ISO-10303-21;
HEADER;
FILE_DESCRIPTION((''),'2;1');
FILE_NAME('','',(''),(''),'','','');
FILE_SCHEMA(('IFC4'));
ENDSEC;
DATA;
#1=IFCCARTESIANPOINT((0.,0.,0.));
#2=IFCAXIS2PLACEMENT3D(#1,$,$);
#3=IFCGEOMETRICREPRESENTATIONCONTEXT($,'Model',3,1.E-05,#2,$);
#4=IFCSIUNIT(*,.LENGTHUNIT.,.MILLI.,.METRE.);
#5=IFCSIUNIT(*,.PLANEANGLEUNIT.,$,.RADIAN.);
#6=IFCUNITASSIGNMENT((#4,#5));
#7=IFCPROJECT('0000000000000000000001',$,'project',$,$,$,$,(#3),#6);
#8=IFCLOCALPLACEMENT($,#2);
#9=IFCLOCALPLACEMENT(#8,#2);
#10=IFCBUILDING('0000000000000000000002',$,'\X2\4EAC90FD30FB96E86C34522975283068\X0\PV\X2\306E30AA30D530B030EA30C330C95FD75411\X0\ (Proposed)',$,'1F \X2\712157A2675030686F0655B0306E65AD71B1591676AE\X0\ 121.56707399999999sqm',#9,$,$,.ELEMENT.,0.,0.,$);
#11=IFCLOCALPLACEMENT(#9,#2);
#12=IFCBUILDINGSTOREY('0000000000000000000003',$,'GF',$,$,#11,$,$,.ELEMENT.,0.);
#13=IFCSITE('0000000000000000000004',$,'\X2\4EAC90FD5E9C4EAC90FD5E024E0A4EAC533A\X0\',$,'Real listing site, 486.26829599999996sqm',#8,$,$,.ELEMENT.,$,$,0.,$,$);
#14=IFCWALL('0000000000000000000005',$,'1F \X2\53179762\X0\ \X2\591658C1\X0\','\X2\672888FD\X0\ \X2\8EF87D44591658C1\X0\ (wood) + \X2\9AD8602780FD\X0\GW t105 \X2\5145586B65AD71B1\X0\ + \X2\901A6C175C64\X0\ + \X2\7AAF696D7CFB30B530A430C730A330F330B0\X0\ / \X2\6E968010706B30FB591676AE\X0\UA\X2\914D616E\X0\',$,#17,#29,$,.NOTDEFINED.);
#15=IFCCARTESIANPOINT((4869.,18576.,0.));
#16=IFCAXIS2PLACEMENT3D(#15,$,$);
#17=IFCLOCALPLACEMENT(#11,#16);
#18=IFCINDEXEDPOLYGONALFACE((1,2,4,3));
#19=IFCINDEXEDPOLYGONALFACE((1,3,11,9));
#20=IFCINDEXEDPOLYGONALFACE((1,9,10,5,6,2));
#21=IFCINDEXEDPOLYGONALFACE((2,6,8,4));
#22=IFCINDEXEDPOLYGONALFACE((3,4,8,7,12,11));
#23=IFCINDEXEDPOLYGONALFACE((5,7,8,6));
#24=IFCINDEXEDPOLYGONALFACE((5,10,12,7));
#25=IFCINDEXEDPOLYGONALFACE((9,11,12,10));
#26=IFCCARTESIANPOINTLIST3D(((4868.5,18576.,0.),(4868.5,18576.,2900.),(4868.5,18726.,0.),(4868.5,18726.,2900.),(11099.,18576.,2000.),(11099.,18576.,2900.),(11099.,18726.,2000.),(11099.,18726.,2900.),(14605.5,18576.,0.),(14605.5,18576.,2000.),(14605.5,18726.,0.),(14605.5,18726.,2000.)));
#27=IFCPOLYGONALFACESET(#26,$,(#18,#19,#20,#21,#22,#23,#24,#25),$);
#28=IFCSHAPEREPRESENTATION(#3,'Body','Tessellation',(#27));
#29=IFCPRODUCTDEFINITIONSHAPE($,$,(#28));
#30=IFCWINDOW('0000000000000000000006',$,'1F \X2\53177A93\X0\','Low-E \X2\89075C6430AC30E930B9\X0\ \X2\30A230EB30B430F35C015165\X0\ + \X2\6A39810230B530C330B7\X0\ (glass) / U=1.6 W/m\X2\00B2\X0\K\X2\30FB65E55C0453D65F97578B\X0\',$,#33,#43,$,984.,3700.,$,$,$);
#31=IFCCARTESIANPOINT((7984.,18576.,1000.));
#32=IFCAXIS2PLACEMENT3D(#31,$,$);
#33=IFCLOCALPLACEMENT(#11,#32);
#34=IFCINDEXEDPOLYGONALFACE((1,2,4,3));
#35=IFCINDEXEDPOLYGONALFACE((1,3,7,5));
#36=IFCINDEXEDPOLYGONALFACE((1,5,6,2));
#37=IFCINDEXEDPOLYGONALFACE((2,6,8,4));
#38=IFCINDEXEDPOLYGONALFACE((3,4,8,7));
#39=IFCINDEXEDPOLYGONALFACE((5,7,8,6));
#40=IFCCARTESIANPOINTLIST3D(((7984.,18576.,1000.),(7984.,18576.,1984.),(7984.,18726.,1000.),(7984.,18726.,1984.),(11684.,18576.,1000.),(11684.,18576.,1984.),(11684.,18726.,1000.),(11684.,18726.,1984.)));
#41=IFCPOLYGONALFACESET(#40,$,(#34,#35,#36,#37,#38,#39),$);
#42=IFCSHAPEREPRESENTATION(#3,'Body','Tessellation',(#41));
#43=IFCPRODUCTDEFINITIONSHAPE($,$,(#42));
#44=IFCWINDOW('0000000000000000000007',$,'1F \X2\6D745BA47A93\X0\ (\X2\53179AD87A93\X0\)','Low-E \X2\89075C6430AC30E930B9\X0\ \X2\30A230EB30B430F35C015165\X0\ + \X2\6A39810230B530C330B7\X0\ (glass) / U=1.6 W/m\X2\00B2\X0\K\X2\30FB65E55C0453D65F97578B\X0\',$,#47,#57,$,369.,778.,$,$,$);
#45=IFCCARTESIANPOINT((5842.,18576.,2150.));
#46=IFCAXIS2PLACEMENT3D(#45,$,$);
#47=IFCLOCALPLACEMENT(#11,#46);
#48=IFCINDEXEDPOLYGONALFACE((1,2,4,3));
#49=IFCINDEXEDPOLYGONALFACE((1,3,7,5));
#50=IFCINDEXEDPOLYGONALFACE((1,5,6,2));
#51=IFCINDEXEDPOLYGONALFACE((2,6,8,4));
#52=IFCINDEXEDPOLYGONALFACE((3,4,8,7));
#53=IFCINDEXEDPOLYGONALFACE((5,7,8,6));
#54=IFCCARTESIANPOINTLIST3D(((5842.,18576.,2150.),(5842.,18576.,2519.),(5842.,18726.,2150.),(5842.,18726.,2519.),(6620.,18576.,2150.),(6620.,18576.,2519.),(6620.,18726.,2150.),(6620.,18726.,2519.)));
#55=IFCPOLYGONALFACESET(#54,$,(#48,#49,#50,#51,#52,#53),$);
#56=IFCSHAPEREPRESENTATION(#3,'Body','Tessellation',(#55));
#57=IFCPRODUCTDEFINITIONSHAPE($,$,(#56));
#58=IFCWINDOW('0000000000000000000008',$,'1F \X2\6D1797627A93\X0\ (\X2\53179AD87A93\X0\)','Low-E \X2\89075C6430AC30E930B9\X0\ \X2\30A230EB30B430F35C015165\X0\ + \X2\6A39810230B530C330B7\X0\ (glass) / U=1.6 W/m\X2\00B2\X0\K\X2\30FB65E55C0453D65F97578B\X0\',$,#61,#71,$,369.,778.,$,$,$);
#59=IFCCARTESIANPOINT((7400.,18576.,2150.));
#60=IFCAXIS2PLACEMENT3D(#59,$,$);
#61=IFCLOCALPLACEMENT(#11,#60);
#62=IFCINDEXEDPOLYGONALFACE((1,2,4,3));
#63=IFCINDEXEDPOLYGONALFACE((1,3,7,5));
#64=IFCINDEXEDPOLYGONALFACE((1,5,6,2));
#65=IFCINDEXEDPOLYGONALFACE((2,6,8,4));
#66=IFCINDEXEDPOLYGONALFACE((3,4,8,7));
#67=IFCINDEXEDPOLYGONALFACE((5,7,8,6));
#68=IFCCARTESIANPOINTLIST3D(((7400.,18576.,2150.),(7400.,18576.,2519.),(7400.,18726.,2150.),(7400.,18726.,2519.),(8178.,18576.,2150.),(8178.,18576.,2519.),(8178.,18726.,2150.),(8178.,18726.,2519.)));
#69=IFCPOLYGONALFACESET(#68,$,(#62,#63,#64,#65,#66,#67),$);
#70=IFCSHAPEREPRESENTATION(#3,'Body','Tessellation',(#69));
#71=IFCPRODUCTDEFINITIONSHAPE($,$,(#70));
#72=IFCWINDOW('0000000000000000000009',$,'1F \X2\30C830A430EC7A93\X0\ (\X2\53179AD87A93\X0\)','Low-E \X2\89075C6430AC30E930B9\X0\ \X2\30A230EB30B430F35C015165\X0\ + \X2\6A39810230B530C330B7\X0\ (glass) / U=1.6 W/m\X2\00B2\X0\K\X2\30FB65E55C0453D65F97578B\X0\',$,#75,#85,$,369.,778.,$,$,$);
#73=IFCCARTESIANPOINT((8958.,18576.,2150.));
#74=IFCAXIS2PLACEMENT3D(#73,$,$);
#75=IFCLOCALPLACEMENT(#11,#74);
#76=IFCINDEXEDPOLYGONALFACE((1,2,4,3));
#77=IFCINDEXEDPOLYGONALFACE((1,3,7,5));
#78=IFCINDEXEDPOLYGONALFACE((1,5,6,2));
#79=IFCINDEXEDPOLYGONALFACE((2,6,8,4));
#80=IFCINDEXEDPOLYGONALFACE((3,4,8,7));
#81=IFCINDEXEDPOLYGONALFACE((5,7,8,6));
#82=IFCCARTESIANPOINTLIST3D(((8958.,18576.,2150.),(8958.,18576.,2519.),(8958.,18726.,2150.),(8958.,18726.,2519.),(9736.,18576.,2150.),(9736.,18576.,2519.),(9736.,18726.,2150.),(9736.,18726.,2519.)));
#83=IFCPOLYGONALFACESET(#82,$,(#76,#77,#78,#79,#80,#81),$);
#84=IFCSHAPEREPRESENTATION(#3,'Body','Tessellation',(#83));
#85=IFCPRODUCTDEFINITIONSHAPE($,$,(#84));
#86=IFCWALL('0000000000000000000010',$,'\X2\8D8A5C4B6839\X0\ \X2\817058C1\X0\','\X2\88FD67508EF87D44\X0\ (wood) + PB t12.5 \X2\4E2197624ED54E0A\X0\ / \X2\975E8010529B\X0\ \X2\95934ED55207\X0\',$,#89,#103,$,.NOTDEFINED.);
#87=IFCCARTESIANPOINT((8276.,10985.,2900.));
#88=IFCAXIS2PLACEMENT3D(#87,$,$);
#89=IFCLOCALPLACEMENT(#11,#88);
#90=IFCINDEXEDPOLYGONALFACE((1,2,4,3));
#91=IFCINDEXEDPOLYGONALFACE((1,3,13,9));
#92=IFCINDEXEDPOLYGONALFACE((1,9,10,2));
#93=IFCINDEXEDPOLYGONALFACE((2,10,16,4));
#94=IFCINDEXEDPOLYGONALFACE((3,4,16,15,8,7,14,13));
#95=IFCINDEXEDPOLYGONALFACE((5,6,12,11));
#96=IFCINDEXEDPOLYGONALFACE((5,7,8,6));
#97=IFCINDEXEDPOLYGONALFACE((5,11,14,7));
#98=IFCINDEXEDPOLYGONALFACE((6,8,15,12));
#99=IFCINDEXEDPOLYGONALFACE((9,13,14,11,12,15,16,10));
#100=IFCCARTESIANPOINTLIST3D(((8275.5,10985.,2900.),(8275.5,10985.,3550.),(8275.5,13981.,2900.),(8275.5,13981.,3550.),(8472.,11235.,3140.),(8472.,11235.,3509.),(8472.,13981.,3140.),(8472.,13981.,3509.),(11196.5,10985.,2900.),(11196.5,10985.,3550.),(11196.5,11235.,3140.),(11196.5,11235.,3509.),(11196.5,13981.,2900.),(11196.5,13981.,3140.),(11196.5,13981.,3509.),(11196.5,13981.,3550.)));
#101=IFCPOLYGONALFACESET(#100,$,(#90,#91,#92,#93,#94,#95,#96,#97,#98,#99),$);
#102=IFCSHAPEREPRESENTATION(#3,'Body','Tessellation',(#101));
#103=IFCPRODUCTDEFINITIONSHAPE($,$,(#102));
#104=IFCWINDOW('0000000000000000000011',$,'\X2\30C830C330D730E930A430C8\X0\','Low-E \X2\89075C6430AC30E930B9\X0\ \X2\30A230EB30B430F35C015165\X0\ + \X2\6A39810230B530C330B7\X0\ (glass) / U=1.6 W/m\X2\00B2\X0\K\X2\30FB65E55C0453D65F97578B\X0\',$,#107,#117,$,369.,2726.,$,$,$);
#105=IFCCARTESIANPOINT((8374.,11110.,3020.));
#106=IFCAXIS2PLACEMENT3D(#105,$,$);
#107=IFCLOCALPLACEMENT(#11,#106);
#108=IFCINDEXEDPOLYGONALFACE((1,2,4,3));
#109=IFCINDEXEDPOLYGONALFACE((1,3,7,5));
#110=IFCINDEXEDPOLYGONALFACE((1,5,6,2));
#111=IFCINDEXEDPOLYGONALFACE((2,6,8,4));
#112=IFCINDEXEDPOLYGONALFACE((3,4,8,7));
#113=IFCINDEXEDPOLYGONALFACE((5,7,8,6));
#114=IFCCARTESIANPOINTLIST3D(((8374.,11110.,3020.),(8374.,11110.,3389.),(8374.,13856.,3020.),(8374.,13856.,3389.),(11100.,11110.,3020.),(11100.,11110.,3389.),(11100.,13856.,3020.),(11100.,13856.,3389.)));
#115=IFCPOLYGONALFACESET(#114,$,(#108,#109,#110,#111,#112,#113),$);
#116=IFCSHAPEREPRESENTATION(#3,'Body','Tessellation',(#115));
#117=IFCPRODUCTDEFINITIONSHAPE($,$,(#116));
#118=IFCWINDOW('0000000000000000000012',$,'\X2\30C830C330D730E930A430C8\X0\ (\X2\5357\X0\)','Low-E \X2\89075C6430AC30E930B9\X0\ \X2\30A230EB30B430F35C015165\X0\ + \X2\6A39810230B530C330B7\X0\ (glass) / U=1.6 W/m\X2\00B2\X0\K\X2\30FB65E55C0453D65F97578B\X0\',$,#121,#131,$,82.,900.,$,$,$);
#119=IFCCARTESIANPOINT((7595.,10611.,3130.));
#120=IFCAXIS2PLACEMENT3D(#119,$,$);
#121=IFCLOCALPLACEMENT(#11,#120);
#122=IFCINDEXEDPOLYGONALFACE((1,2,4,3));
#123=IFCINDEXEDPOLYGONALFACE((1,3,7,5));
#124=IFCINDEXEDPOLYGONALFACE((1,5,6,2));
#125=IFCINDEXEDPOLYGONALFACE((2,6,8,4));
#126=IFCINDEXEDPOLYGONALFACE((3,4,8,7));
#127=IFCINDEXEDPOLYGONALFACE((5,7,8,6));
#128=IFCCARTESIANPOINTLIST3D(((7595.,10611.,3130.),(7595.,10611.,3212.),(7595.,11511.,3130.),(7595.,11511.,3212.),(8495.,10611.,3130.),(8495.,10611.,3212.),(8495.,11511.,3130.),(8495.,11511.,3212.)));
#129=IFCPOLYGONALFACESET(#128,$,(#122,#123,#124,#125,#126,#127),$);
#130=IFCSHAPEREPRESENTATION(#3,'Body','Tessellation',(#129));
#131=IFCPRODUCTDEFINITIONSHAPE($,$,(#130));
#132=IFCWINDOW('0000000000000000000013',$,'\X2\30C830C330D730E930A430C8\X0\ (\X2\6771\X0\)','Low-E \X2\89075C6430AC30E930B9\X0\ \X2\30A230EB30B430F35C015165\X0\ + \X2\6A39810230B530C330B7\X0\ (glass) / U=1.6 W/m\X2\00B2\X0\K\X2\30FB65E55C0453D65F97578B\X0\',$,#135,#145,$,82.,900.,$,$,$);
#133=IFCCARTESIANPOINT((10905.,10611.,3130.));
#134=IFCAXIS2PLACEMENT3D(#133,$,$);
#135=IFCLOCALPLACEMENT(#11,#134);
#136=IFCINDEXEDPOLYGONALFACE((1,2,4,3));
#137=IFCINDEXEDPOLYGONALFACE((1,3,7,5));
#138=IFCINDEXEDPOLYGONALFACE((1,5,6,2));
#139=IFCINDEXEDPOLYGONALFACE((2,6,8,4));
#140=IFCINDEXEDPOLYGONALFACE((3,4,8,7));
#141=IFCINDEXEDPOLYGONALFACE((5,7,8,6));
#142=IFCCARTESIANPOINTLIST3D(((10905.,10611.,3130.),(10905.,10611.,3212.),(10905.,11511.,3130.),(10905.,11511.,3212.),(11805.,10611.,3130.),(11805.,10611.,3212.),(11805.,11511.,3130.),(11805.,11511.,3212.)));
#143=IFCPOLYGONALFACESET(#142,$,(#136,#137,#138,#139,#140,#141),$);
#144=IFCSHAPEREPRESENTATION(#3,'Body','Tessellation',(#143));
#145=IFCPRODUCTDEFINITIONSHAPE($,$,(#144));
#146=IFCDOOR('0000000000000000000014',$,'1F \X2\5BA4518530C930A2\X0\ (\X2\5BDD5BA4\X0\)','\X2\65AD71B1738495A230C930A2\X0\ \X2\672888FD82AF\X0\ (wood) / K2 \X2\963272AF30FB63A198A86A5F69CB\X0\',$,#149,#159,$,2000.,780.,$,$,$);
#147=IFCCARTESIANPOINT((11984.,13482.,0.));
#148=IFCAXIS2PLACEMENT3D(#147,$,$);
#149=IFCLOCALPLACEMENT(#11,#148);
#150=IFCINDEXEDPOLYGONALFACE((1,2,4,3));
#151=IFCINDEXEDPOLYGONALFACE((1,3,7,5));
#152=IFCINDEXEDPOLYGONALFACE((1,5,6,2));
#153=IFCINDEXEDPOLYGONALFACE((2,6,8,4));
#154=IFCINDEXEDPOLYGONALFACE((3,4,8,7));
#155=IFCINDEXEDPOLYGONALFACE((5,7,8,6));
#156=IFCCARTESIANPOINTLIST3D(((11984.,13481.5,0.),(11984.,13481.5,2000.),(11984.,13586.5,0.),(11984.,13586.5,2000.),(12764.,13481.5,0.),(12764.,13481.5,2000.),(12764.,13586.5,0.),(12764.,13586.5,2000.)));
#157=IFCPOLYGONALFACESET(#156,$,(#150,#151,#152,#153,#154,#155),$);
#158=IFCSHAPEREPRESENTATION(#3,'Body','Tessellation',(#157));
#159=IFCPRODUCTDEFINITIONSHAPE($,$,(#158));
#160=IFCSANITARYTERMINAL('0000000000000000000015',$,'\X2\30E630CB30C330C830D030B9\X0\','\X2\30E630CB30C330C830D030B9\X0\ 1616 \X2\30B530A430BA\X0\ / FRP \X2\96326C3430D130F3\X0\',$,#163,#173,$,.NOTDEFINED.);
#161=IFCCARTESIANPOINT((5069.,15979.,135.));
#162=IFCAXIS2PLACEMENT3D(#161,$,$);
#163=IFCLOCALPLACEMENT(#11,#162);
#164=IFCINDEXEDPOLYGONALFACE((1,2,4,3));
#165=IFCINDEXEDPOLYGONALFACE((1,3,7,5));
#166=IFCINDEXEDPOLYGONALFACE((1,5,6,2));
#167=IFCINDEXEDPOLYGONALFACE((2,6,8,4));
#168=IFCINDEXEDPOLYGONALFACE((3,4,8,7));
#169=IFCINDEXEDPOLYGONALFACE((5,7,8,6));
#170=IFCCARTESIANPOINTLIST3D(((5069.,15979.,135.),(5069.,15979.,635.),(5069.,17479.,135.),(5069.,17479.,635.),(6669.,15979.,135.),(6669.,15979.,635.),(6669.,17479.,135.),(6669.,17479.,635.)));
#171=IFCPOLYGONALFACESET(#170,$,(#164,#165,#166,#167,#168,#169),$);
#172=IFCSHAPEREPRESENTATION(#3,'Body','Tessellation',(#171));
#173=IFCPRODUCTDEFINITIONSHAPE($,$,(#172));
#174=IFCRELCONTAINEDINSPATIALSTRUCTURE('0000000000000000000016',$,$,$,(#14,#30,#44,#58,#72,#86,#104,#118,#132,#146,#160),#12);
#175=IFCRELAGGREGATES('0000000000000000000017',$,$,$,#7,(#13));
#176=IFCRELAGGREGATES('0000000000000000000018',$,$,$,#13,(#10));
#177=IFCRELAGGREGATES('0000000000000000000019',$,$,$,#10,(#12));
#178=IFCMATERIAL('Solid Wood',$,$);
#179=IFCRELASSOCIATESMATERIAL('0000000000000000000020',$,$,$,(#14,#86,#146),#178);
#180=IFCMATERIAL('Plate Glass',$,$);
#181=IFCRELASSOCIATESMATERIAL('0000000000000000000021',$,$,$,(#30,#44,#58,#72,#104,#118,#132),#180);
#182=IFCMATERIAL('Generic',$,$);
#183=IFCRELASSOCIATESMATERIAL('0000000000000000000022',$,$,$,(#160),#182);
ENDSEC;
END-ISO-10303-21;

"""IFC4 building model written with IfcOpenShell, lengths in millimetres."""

from ifc_helpers import new_model, si_unit, frame, frame_2d, origin, place, context, project, spatial, rectangle, extrude, material, element, fill, save


model = new_model("IFC4")

# Units and contexts
model_context = context("Model", 3, precision=1e-05, world=origin())
ifc_project = project(units=[si_unit("LENGTHUNIT", "METRE", prefix="MILLI"), si_unit("PLANEANGLEUNIT", "RADIAN")], contexts=[model_context])

# Site, building, storey
site_placement = place(None, origin())
site = spatial("IfcSite", under=ifc_project, at=site_placement, Name="京都府京都市上京区", ObjectType="Real listing site, 486.26829599999996sqm", CompositionType="ELEMENT", RefElevation=0.0)
building_placement = place(site_placement, origin())
building = spatial("IfcBuilding", under=site, at=building_placement, Name="京都・雨水利用とPVのオフグリッド志向 (Proposed)", ObjectType="1F 無垢材と漆喰の断熱外皮 121.56707399999999sqm", CompositionType="ELEMENT", ElevationOfRefHeight=0.0, ElevationOfTerrain=0.0)
storey_placement = place(building_placement, origin())
storey = spatial("IfcBuildingStorey", under=building, at=storey_placement, Name="GF", CompositionType="ELEMENT", Elevation=0.0)

# Shared definitions
ifc_material_1 = material(Name="Solid Wood")

# Wall, openings, windows
wall_1_placement = place(storey_placement, frame((4869.0, 18576.0, 0.0)))
wall_1 = element("IfcWall", 1, at=wall_1_placement, inside=storey, material=ifc_material_1, Name="1F 北面 外壁", Description="木製 軸組外壁 (wood) + 高性能GW t105 充填断熱 + 通気層 + 窯業系サイディング / 準耐火・外皮UA配慮", PredefinedType="NOTDEFINED", context=model_context, shape_type="SweptSolid", body=[
    extrude(rectangle(XDim=9737.0, YDim=150.0, at=frame_2d((4868.0, 75.0))), frame((4869.0, 18576.0, 0.0)), (0.0, 0.0, 1.0), 2900.0),
])
opening_1_placement = place(storey_placement, frame((7984.0, 18576.0, 1000.0)))
opening_1 = element("IfcOpeningElement", 2, at=opening_1_placement, cuts=wall_1, PredefinedType="NOTDEFINED", context=model_context, shape_type="SweptSolid", body=[
    extrude(rectangle(XDim=3700.0, YDim=150.0, at=frame_2d((1850.0, 75.0))), frame((7984.0, 18576.0, 1000.0)), (0.0, 0.0, 1.0), 984.0),
])
opening_2_placement = place(storey_placement, frame((5842.0, 18576.0, 2150.0)))
opening_2 = element("IfcOpeningElement", 3, at=opening_2_placement, cuts=wall_1, PredefinedType="NOTDEFINED", context=model_context, shape_type="SweptSolid", body=[
    extrude(rectangle(XDim=778.0, YDim=150.0, at=frame_2d((389.0, 75.0))), frame((5842.0, 18576.0, 2150.0)), (0.0, 0.0, 1.0), 369.0),
])
opening_3_placement = place(storey_placement, frame((7400.0, 18576.0, 2150.0)))
opening_3 = element("IfcOpeningElement", 4, at=opening_3_placement, cuts=wall_1, PredefinedType="NOTDEFINED", context=model_context, shape_type="SweptSolid", body=[
    extrude(rectangle(XDim=778.0, YDim=150.0, at=frame_2d((389.0, 75.0))), frame((7400.0, 18576.0, 2150.0)), (0.0, 0.0, 1.0), 369.0),
])
opening_4_placement = place(storey_placement, frame((8958.0, 18576.0, 2150.0)))
opening_4 = element("IfcOpeningElement", 5, at=opening_4_placement, cuts=wall_1, PredefinedType="NOTDEFINED", context=model_context, shape_type="SweptSolid", body=[
    extrude(rectangle(XDim=778.0, YDim=150.0, at=frame_2d((389.0, 75.0))), frame((8958.0, 18576.0, 2150.0)), (0.0, 0.0, 1.0), 369.0),
])
ifc_material_2 = material(Name="Plate Glass")
window_1_placement = place(storey_placement, frame((7984.0, 18576.0, 1000.0)))
window_1 = element("IfcWindow", 6, at=window_1_placement, inside=storey, material=ifc_material_2, Name="1F 北窓", Description="Low-E 複層ガラス アルゴン封入 + 樹脂サッシ (glass) / U=1.6 W/m²K・日射取得型", OverallHeight=984.0, OverallWidth=3700.0, context=model_context, shape_type="SweptSolid", body=[
    extrude(rectangle(XDim=3700.0, YDim=150.0, at=frame_2d((1850.0, 75.0))), frame((7984.0, 18576.0, 1000.0)), (0.0, 0.0, 1.0), 984.0),
])
fill(opening_1, window_1)
window_2_placement = place(storey_placement, frame((5842.0, 18576.0, 2150.0)))
window_2 = element("IfcWindow", 7, at=window_2_placement, inside=storey, material=ifc_material_2, Name="1F 浴室窓 (北高窓)", Description="Low-E 複層ガラス アルゴン封入 + 樹脂サッシ (glass) / U=1.6 W/m²K・日射取得型", OverallHeight=369.0, OverallWidth=778.0, context=model_context, shape_type="SweptSolid", body=[
    extrude(rectangle(XDim=778.0, YDim=150.0, at=frame_2d((389.0, 75.0))), frame((5842.0, 18576.0, 2150.0)), (0.0, 0.0, 1.0), 369.0),
])
fill(opening_2, window_2)
window_3_placement = place(storey_placement, frame((7400.0, 18576.0, 2150.0)))
window_3 = element("IfcWindow", 8, at=window_3_placement, inside=storey, material=ifc_material_2, Name="1F 洗面窓 (北高窓)", Description="Low-E 複層ガラス アルゴン封入 + 樹脂サッシ (glass) / U=1.6 W/m²K・日射取得型", OverallHeight=369.0, OverallWidth=778.0, context=model_context, shape_type="SweptSolid", body=[
    extrude(rectangle(XDim=778.0, YDim=150.0, at=frame_2d((389.0, 75.0))), frame((7400.0, 18576.0, 2150.0)), (0.0, 0.0, 1.0), 369.0),
])
fill(opening_3, window_3)
window_4_placement = place(storey_placement, frame((8958.0, 18576.0, 2150.0)))
window_4 = element("IfcWindow", 9, at=window_4_placement, inside=storey, material=ifc_material_2, Name="1F トイレ窓 (北高窓)", Description="Low-E 複層ガラス アルゴン封入 + 樹脂サッシ (glass) / U=1.6 W/m²K・日射取得型", OverallHeight=369.0, OverallWidth=778.0, context=model_context, shape_type="SweptSolid", body=[
    extrude(rectangle(XDim=778.0, YDim=150.0, at=frame_2d((389.0, 75.0))), frame((8958.0, 18576.0, 2150.0)), (0.0, 0.0, 1.0), 369.0),
])
fill(opening_4, window_4)

# Wall, openings, windows
wall_2_placement = place(storey_placement, frame((8276.0, 10985.0, 2900.0)))
wall_2 = element("IfcWall", 10, at=wall_2_placement, inside=storey, material=ifc_material_1, Name="越屋根 腰壁", Description="製材軸組 (wood) + PB t12.5 両面仕上 / 非耐力 間仕切", PredefinedType="NOTDEFINED", context=model_context, shape_type="SweptSolid", body=[
    extrude(rectangle(XDim=2921.0, YDim=2996.0, at=frame_2d((1460.0, 1498.0))), frame((8276.0, 10985.0, 2900.0)), (0.0, 0.0, 1.0), 650.0),
])
opening_5_placement = place(storey_placement, frame((8374.0, 11110.0, 3020.0)))
opening_5 = element("IfcOpeningElement", 11, at=opening_5_placement, cuts=wall_2, PredefinedType="NOTDEFINED", context=model_context, shape_type="SweptSolid", body=[
    extrude(rectangle(XDim=2726.0, YDim=2746.0, at=frame_2d((1363.0, 1373.0))), frame((8374.0, 11110.0, 3020.0)), (0.0, 0.0, 1.0), 369.0),
])
opening_6_placement = place(storey_placement, frame((7595.0, 10611.0, 3130.0)))
opening_6 = element("IfcOpeningElement", 12, at=opening_6_placement, cuts=wall_2, PredefinedType="NOTDEFINED", context=model_context, shape_type="SweptSolid", body=[
    extrude(rectangle(XDim=900.0, YDim=900.0, at=frame_2d((450.0, 450.0))), frame((7595.0, 10611.0, 3130.0)), (0.0, 0.0, 1.0), 82.0),
])
opening_7_placement = place(storey_placement, frame((10905.0, 10611.0, 3130.0)))
opening_7 = element("IfcOpeningElement", 13, at=opening_7_placement, cuts=wall_2, PredefinedType="NOTDEFINED", context=model_context, shape_type="SweptSolid", body=[
    extrude(rectangle(XDim=900.0, YDim=900.0, at=frame_2d((450.0, 450.0))), frame((10905.0, 10611.0, 3130.0)), (0.0, 0.0, 1.0), 82.0),
])
window_5_placement = place(storey_placement, frame((8374.0, 11110.0, 3020.0)))
window_5 = element("IfcWindow", 14, at=window_5_placement, inside=storey, material=ifc_material_2, Name="トップライト", Description="Low-E 複層ガラス アルゴン封入 + 樹脂サッシ (glass) / U=1.6 W/m²K・日射取得型", OverallHeight=369.0, OverallWidth=2726.0, context=model_context, shape_type="SweptSolid", body=[
    extrude(rectangle(XDim=2726.0, YDim=2746.0, at=frame_2d((1363.0, 1373.0))), frame((8374.0, 11110.0, 3020.0)), (0.0, 0.0, 1.0), 369.0),
])
fill(opening_5, window_5)
window_6_placement = place(storey_placement, frame((7595.0, 10611.0, 3130.0)))
window_6 = element("IfcWindow", 15, at=window_6_placement, inside=storey, material=ifc_material_2, Name="トップライト (南)", Description="Low-E 複層ガラス アルゴン封入 + 樹脂サッシ (glass) / U=1.6 W/m²K・日射取得型", OverallHeight=82.0, OverallWidth=900.0, context=model_context, shape_type="SweptSolid", body=[
    extrude(rectangle(XDim=900.0, YDim=900.0, at=frame_2d((450.0, 450.0))), frame((7595.0, 10611.0, 3130.0)), (0.0, 0.0, 1.0), 82.0),
])
fill(opening_6, window_6)
window_7_placement = place(storey_placement, frame((10905.0, 10611.0, 3130.0)))
window_7 = element("IfcWindow", 16, at=window_7_placement, inside=storey, material=ifc_material_2, Name="トップライト (東)", Description="Low-E 複層ガラス アルゴン封入 + 樹脂サッシ (glass) / U=1.6 W/m²K・日射取得型", OverallHeight=82.0, OverallWidth=900.0, context=model_context, shape_type="SweptSolid", body=[
    extrude(rectangle(XDim=900.0, YDim=900.0, at=frame_2d((450.0, 450.0))), frame((10905.0, 10611.0, 3130.0)), (0.0, 0.0, 1.0), 82.0),
])
fill(opening_7, window_7)

# Door
door_1_placement = place(storey_placement, frame((11984.0, 13482.0, 0.0)))
element("IfcDoor", 17, at=door_1_placement, inside=storey, material=ifc_material_1, Name="1F 室内ドア (寝室)", Description="断熱玄関ドア 木製芯 (wood) / K2 防犯・採風機構", OverallHeight=2000.0, OverallWidth=780.0, context=model_context, shape_type="SweptSolid", body=[
    extrude(rectangle(XDim=780.0, YDim=105.0, at=frame_2d((390.0, 52.0))), frame((11984.0, 13482.0, 0.0)), (0.0, 0.0, 1.0), 2000.0),
])

# Sanitary terminal
ifc_material_3 = material(Name="Generic")
sanitary_terminal_1_placement = place(storey_placement, frame((5069.0, 15979.0, 135.0)))
element("IfcSanitaryTerminal", 18, at=sanitary_terminal_1_placement, inside=storey, material=ifc_material_3, Name="ユニットバス", Description="ユニットバス 1616 サイズ / FRP 防水パン", PredefinedType="NOTDEFINED", context=model_context, shape_type="SweptSolid", body=[
    extrude(rectangle(XDim=1600.0, YDim=1500.0, at=frame_2d((800.0, 750.0))), frame((5069.0, 15979.0, 135.0)), (0.0, 0.0, 1.0), 500.0),
])

save(model, "model.ifc")
